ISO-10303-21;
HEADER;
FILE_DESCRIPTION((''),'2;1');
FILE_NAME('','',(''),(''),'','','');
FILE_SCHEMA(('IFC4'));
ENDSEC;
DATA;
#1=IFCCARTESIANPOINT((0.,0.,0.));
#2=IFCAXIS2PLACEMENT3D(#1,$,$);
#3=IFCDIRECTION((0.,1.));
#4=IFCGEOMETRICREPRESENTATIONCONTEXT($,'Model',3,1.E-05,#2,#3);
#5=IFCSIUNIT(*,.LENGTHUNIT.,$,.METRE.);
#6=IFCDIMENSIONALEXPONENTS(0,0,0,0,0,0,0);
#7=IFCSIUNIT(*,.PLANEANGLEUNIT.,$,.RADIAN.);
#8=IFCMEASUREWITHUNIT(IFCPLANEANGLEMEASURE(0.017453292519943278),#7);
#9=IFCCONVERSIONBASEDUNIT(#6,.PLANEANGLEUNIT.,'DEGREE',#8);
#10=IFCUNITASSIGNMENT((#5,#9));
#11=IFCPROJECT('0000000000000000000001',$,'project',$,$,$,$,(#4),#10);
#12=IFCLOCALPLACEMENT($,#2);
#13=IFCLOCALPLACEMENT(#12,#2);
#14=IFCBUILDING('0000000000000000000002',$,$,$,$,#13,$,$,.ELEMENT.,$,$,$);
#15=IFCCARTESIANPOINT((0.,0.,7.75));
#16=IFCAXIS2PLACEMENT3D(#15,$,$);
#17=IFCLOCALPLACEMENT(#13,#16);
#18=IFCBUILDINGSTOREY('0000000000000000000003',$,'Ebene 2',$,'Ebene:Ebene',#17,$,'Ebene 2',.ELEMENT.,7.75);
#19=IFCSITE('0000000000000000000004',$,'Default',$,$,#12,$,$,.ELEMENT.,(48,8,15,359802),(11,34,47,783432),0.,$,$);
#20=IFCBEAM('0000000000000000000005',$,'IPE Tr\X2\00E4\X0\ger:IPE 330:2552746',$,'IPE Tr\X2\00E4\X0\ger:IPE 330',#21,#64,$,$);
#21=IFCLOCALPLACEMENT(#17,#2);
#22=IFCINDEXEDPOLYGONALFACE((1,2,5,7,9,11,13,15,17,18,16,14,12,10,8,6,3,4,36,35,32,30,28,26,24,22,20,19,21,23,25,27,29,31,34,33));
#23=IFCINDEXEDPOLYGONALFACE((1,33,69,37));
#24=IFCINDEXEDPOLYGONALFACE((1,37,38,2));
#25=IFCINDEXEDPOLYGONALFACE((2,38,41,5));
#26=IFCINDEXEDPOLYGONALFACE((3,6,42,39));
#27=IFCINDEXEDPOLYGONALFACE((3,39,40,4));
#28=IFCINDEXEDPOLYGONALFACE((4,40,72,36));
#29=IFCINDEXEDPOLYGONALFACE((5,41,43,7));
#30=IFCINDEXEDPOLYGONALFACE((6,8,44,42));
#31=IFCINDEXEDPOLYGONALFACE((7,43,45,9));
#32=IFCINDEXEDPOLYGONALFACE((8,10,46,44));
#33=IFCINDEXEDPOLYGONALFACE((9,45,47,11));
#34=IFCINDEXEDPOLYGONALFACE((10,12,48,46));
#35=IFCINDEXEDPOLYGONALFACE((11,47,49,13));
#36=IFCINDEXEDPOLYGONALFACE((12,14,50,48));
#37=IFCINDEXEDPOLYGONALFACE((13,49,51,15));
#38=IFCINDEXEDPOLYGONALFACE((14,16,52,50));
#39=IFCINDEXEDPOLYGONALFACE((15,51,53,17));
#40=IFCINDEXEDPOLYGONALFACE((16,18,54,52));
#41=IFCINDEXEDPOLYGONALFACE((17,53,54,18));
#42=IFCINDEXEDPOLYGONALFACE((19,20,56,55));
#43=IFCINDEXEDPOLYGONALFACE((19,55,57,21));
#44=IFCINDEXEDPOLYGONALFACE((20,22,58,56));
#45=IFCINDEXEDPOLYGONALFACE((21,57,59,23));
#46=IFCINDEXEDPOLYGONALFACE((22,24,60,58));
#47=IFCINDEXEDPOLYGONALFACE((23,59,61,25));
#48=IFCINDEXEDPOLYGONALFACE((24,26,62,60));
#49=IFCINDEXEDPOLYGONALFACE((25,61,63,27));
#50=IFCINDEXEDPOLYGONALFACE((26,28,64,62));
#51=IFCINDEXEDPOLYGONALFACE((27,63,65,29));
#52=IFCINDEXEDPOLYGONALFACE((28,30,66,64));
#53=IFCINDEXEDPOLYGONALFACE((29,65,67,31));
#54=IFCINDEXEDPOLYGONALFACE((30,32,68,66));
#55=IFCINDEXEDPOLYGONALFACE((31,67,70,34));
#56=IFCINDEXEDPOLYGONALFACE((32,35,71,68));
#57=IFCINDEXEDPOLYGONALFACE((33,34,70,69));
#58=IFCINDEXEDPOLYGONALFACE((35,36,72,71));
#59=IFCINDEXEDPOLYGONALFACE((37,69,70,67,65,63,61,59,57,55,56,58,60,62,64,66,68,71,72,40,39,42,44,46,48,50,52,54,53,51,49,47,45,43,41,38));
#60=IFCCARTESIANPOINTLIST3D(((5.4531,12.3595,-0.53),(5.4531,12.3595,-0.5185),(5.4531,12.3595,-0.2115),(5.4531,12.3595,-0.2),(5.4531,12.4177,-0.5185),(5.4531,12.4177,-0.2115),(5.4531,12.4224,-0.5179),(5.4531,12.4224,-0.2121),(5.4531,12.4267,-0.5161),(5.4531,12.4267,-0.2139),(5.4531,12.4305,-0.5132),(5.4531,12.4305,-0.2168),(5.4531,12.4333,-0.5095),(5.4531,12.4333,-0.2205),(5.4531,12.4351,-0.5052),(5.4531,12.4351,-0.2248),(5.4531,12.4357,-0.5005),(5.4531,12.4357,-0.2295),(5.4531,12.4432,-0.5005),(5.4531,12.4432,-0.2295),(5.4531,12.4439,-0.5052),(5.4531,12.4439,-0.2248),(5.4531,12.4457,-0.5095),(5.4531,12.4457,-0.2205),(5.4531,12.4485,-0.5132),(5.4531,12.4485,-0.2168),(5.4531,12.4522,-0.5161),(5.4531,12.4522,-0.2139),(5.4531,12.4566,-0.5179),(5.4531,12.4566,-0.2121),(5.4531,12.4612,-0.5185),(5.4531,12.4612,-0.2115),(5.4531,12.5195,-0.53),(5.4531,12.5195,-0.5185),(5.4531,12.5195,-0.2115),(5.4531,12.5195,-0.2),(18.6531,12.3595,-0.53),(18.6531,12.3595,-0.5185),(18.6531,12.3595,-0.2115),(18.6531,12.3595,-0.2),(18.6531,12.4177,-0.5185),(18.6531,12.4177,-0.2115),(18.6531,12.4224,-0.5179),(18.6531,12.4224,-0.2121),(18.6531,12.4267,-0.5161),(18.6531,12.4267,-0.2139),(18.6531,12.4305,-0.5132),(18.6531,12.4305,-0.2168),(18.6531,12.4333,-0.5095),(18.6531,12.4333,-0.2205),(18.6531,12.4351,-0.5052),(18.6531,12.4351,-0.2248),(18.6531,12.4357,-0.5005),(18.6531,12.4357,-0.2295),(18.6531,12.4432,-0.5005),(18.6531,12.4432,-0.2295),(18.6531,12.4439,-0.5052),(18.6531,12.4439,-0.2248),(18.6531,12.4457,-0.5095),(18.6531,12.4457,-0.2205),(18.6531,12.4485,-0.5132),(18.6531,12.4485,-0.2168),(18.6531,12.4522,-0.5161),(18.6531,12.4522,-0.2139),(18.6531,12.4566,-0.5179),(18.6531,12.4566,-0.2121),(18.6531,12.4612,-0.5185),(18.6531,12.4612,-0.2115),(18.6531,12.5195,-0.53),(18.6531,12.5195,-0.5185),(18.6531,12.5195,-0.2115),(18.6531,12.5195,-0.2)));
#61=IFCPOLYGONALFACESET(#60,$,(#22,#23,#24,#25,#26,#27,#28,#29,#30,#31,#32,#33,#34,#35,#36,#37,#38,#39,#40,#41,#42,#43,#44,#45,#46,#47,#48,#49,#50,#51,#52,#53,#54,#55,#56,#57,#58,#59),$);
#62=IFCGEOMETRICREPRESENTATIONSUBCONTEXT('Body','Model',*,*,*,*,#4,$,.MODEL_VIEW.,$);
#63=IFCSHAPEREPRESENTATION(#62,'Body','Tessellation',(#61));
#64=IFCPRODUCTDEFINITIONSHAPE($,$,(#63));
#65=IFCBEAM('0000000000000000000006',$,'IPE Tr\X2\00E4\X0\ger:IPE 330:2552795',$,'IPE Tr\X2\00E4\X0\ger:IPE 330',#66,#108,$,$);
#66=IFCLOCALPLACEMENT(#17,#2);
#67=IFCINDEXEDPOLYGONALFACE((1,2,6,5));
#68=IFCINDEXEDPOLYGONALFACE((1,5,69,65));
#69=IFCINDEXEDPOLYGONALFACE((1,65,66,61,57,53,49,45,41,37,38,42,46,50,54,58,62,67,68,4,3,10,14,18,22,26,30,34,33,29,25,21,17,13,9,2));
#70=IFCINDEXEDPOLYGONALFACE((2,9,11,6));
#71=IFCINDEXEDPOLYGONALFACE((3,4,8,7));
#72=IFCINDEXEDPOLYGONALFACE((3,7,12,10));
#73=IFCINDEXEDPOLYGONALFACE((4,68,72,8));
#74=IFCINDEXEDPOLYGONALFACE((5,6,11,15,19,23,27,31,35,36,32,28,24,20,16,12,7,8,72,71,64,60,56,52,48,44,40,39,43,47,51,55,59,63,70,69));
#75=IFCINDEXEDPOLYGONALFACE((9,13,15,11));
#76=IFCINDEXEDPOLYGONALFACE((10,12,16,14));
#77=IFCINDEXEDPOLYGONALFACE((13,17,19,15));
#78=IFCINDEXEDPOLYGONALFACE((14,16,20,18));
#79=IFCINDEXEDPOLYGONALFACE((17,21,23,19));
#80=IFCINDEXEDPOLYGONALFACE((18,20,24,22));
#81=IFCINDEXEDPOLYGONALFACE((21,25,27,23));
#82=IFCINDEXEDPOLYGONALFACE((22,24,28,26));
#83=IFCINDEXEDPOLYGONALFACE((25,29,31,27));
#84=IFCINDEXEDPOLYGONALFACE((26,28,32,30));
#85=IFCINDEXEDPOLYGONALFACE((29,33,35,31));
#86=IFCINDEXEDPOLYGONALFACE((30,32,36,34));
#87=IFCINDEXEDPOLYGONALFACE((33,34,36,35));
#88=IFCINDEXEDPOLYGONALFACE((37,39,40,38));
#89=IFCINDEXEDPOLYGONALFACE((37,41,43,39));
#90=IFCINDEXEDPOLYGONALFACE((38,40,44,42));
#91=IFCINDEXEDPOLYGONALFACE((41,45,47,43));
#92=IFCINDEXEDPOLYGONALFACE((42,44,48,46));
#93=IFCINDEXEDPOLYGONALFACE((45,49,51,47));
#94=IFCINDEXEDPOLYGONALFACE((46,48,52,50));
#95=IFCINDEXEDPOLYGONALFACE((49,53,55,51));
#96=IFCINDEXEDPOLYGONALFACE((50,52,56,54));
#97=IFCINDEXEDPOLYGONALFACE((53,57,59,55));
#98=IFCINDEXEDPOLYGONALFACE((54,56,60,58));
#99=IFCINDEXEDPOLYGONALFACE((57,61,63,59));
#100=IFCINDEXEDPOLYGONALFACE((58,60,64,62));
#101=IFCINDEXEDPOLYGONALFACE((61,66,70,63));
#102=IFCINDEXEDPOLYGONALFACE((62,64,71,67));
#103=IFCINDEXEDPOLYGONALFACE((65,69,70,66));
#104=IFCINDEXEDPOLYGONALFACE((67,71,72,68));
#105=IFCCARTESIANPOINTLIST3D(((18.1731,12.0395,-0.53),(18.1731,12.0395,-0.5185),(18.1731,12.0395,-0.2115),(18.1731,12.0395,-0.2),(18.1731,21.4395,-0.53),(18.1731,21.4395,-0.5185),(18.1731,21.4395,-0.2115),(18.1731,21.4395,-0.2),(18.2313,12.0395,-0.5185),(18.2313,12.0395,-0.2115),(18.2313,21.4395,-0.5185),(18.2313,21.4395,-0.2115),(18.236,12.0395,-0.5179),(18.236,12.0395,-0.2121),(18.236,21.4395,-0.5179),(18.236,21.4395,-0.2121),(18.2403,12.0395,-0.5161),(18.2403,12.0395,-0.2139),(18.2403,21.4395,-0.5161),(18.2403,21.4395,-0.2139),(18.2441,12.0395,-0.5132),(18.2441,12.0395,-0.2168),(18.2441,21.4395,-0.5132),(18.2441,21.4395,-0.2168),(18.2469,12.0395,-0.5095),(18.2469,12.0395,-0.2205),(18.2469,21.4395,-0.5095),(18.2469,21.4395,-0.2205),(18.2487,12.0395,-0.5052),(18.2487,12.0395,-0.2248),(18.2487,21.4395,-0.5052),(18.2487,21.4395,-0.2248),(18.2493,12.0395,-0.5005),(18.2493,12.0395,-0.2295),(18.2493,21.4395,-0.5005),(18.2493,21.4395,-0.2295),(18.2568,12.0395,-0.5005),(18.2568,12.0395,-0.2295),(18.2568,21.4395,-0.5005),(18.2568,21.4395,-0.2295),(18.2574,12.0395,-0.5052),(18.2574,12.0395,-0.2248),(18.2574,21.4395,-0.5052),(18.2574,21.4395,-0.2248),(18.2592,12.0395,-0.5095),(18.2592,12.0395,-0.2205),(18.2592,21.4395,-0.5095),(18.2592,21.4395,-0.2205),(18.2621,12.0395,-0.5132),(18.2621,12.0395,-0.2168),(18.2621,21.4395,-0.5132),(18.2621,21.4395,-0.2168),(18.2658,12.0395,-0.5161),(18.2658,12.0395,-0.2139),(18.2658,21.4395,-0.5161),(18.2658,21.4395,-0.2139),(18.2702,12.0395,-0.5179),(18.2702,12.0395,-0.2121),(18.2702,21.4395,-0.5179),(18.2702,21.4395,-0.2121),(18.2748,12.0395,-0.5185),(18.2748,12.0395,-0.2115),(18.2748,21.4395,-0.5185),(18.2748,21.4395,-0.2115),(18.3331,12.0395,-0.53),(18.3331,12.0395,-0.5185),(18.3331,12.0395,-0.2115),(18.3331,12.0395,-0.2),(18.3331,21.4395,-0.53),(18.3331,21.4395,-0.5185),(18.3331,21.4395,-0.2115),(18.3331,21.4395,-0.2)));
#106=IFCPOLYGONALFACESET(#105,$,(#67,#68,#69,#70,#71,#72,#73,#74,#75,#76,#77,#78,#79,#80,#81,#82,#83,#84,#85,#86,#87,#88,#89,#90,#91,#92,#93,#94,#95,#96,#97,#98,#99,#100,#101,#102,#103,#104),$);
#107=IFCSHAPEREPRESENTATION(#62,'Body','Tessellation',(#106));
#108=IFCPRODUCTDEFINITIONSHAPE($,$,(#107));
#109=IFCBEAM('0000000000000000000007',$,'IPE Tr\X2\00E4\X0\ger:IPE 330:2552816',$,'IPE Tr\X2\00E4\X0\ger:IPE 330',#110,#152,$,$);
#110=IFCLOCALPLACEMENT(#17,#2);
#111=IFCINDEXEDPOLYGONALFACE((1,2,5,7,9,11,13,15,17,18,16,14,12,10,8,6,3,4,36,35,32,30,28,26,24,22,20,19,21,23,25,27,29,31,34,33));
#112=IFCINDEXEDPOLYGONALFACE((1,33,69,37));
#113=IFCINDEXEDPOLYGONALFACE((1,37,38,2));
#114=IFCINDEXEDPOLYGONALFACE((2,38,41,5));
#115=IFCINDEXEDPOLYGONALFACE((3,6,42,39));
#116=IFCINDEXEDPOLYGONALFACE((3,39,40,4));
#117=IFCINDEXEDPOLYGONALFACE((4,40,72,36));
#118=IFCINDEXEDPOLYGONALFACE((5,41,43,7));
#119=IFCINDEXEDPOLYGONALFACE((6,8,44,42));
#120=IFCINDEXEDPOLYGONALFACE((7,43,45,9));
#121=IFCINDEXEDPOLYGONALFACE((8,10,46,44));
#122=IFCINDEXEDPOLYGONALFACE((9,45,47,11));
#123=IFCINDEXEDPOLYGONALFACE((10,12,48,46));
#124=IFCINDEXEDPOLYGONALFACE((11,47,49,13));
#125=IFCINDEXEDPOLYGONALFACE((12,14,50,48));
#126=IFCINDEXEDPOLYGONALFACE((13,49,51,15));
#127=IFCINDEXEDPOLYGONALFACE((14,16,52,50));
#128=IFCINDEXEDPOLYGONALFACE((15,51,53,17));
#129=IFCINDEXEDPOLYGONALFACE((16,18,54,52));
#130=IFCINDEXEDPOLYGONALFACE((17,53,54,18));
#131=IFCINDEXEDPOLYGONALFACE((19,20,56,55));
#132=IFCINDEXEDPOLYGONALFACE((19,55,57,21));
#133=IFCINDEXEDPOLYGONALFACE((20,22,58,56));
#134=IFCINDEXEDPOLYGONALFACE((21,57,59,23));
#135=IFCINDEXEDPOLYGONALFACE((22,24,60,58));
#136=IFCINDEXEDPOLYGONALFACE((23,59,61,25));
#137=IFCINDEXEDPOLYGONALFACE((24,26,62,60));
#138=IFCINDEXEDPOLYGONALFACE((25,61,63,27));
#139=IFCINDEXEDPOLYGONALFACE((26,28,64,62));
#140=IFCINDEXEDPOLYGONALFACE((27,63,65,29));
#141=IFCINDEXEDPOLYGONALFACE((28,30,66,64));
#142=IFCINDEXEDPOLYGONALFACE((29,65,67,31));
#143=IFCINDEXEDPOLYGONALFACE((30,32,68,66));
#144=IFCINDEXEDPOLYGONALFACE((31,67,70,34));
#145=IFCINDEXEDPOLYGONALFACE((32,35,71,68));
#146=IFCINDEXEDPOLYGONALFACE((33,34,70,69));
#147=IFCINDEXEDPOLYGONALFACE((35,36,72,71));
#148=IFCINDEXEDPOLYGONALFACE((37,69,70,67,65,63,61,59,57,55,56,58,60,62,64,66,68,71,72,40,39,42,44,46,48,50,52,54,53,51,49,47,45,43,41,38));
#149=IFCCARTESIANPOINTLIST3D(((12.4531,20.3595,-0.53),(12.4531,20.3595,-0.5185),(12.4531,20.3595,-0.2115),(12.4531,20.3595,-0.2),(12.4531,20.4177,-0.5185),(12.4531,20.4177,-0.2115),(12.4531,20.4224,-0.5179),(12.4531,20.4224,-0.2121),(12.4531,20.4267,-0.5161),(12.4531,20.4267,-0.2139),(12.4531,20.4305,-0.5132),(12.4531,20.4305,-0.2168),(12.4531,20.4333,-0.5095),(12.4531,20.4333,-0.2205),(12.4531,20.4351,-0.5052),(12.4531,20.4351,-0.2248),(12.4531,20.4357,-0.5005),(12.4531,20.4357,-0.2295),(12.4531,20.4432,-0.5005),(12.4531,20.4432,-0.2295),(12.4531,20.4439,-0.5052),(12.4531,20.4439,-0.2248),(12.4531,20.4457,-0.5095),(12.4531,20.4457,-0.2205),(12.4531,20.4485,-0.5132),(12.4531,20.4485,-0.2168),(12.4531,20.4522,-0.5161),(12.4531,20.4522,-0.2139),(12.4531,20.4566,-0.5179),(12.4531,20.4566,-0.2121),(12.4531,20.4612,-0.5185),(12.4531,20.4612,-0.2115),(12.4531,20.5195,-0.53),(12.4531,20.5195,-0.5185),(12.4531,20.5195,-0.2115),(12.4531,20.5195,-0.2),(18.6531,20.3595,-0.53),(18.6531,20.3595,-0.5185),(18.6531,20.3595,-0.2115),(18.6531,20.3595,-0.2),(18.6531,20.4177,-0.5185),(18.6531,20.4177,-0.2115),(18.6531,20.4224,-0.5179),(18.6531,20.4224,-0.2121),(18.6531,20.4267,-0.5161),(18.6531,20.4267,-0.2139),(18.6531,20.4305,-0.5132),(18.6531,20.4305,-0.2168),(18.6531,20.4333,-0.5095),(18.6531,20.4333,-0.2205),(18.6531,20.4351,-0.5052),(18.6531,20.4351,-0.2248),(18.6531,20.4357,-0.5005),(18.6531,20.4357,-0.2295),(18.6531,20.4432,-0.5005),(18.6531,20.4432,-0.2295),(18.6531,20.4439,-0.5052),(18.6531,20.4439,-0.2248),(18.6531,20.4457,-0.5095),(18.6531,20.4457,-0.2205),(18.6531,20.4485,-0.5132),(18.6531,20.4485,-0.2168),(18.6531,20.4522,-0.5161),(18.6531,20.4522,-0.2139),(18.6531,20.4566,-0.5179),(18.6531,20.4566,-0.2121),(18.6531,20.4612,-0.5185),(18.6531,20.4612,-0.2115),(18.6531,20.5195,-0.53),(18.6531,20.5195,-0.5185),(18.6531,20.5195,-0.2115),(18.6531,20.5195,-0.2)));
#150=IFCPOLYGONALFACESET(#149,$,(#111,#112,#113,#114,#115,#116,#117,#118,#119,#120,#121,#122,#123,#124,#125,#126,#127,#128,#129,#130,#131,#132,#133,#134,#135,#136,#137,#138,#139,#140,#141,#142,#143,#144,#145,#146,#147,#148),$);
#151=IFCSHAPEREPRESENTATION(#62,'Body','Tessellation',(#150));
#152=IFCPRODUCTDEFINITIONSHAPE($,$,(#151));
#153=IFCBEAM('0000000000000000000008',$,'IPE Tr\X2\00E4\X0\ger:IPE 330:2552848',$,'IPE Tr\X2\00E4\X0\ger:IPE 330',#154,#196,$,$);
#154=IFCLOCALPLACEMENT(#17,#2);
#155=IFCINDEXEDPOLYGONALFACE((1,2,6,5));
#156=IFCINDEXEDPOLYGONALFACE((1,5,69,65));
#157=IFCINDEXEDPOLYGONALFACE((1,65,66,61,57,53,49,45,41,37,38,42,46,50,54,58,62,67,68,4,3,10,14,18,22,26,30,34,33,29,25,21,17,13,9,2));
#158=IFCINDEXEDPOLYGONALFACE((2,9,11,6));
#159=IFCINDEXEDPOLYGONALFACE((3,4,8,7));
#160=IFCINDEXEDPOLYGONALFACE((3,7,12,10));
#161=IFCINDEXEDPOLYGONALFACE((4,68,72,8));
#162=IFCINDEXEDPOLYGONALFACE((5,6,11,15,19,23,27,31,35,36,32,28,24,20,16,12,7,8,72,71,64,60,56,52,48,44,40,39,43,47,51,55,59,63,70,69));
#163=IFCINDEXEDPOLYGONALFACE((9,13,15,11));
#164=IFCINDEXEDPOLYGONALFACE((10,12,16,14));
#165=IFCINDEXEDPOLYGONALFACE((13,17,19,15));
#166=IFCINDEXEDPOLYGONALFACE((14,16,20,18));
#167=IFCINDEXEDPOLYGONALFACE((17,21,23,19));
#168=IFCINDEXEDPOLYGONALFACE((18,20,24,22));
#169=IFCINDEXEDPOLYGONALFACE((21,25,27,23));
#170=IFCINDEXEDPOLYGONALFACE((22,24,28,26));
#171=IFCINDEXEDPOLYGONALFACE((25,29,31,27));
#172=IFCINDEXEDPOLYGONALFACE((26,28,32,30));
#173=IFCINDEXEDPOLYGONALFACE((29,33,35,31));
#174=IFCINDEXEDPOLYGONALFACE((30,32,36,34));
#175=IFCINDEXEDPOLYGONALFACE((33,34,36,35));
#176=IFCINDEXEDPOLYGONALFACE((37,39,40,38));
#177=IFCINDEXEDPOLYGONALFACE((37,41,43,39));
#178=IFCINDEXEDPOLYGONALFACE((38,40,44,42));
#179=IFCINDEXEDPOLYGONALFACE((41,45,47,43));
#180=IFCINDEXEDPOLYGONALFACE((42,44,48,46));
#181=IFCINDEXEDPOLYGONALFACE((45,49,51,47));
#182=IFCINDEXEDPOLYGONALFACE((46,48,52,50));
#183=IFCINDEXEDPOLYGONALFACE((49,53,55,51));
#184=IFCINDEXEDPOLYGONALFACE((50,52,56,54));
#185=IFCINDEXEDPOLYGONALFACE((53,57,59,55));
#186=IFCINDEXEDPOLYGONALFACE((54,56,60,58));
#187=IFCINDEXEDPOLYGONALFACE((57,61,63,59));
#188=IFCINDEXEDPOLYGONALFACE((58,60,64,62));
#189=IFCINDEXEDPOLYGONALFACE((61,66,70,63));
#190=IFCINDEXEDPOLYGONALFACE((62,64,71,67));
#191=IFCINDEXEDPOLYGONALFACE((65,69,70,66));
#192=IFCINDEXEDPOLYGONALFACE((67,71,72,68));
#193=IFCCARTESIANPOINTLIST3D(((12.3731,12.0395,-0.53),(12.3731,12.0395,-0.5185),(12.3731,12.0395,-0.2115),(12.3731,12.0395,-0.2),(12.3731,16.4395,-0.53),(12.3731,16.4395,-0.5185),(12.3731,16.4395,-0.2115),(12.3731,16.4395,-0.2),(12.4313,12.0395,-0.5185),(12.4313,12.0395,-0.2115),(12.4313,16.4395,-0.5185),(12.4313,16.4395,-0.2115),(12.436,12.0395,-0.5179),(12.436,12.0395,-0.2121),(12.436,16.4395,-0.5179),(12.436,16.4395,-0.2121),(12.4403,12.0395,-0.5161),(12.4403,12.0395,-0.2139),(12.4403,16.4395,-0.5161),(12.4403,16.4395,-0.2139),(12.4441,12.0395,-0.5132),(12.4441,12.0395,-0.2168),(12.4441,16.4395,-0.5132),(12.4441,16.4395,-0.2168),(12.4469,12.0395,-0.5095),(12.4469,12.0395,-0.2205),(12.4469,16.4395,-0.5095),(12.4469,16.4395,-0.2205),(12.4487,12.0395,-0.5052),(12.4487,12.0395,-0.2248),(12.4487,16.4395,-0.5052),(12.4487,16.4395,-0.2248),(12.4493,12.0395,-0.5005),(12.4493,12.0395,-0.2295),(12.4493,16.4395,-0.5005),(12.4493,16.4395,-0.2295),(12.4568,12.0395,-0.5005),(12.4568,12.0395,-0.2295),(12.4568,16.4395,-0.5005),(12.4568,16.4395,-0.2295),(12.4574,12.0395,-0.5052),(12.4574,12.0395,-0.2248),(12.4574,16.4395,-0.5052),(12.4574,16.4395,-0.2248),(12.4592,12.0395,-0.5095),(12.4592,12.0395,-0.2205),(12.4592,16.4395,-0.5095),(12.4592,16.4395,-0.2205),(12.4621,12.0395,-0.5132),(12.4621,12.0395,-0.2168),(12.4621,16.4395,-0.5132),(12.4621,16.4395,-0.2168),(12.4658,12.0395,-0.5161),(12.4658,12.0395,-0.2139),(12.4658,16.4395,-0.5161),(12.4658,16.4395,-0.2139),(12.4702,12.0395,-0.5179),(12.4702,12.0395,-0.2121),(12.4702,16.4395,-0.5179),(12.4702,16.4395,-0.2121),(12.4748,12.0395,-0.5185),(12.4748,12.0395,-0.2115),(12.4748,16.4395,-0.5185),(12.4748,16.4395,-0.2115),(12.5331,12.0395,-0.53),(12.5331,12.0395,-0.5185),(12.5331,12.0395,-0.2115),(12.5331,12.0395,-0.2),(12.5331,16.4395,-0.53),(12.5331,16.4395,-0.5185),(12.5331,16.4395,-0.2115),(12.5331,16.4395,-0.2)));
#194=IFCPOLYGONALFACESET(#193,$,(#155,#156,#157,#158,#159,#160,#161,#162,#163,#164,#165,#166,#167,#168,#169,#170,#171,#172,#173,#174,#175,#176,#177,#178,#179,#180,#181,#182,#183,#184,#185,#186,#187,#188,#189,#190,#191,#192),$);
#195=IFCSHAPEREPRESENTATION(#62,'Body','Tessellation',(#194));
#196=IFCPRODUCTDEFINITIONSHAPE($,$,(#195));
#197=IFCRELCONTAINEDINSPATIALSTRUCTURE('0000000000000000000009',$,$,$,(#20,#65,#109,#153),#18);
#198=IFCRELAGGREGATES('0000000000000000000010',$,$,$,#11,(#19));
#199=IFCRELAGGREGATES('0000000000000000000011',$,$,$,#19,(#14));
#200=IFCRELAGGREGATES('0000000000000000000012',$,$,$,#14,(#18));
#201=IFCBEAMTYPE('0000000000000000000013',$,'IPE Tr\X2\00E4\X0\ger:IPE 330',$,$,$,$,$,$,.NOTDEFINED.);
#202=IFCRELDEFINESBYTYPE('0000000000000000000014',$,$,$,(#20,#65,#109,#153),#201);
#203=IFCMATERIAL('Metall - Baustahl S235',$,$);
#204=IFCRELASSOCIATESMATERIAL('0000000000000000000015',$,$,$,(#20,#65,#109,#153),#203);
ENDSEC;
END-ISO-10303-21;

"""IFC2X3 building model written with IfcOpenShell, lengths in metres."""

from ifc_helpers import new_model, entity, si_unit, converted_unit, direction, frame, frame_2d, origin, place, context, subcontext, project, spatial, i_section, extrude, material, type_object, element, save


model = new_model("IFC2X3")

# Units and contexts
model_context = context("Model", 3, precision=1e-05, world=origin(), true_north=direction((0.0, 1.0)))
body_context = subcontext(model_context, "Body", "Model", "MODEL_VIEW")
ifc_project = project(units=[si_unit("LENGTHUNIT", "METRE"), converted_unit("PLANEANGLEUNIT", "DEGREE", entity("IfcPlaneAngleMeasure", 0.017453292519943278), si_unit("PLANEANGLEUNIT", "RADIAN"), dimensions=[0, 0, 0, 0, 0, 0, 0])], contexts=[model_context])

# Site, building, storey
site_placement = place(None, origin())
site = spatial("IfcSite", under=ifc_project, at=site_placement, Name="Default", CompositionType="ELEMENT", RefLatitude=(48, 8, 15, 359802), RefLongitude=(11, 34, 47, 783432), RefElevation=0.0)
building_placement = place(site_placement, origin())
building = spatial("IfcBuilding", under=site, at=building_placement, CompositionType="ELEMENT")
storey_placement = place(building_placement, frame((0.0, 0.0, 7.75)))
storey = spatial("IfcBuildingStorey", under=building, at=storey_placement, Name="Ebene 2", ObjectType="Ebene:Ebene", LongName="Ebene 2", CompositionType="ELEMENT", Elevation=7.75)

# Beams
ifc_material_1 = material(Name="Metall - Baustahl S235")
beam_type = type_object("IfcBeamType", Name="IPE Träger:IPE 330", PredefinedType="NOTDEFINED")
beam_1_placement = place(storey_placement, frame((5.4531, 12.4395, -0.2)))
element("IfcBeam", 1, at=beam_1_placement, inside=storey, type_object=beam_type, material=ifc_material_1, Name="IPE Träger:IPE 330:2552746", ObjectType="IPE Träger:IPE 330", context=body_context, shape_type="SweptSolid", body=[
    extrude(i_section(OverallWidth=0.16, OverallDepth=0.33, WebThickness=0.0075, FlangeThickness=0.0115, FilletRadius=0.018, at=frame_2d((0.0, 0.0), x_axis=(0.0, 1.0))), frame((0.0, 0.0, -0.165), z_axis=(1.0, 0.0, 0.0), x_axis=(0.0, 0.0, -1.0)), (0.0, 0.0, 1.0), 13.2),
])
beam_2_placement = place(storey_placement, frame((18.2531, 21.4395, -0.2), z_axis=(0.0, 0.0, 1.0), x_axis=(0.0, -1.0, 0.0)))
element("IfcBeam", 2, at=beam_2_placement, inside=storey, type_object=beam_type, material=ifc_material_1, Name="IPE Träger:IPE 330:2552795", ObjectType="IPE Träger:IPE 330", context=body_context, shape_type="SweptSolid", body=[
    extrude(i_section(OverallWidth=0.16, OverallDepth=0.33, WebThickness=0.0075, FlangeThickness=0.0115, FilletRadius=0.018, at=frame_2d((0.0, 0.0), x_axis=(0.0, 1.0))), frame((0.0, 0.0, -0.165), z_axis=(1.0, 0.0, 0.0), x_axis=(0.0, 0.0, -1.0)), (0.0, 0.0, 1.0), 9.4),
])
beam_3_placement = place(storey_placement, frame((18.6531, 20.4395, -0.2), z_axis=(0.0, 0.0, 1.0), x_axis=(-1.0, 0.0, 0.0)))
element("IfcBeam", 3, at=beam_3_placement, inside=storey, type_object=beam_type, material=ifc_material_1, Name="IPE Träger:IPE 330:2552816", ObjectType="IPE Träger:IPE 330", context=body_context, shape_type="SweptSolid", body=[
    extrude(i_section(OverallWidth=0.16, OverallDepth=0.33, WebThickness=0.0075, FlangeThickness=0.0115, FilletRadius=0.018, at=frame_2d((0.0, 0.0), x_axis=(0.0, 1.0))), frame((0.0, 0.0, -0.165), z_axis=(1.0, 0.0, 0.0), x_axis=(0.0, 0.0, -1.0)), (0.0, 0.0, 1.0), 6.2),
])
beam_4_placement = place(storey_placement, frame((12.4531, 12.0395, -0.2), z_axis=(0.0, 0.0, 1.0), x_axis=(0.0, 1.0, 0.0)))
element("IfcBeam", 4, at=beam_4_placement, inside=storey, type_object=beam_type, material=ifc_material_1, Name="IPE Träger:IPE 330:2552848", ObjectType="IPE Träger:IPE 330", context=body_context, shape_type="SweptSolid", body=[
    extrude(i_section(OverallWidth=0.16, OverallDepth=0.33, WebThickness=0.0075, FlangeThickness=0.0115, FilletRadius=0.018, at=frame_2d((0.0, 0.0), x_axis=(0.0, 1.0))), frame((0.0, 0.0, -0.165), z_axis=(1.0, 0.0, 0.0), x_axis=(0.0, 0.0, -1.0)), (0.0, 0.0, 1.0), 4.4),
])

save(model, "model.ifc")
